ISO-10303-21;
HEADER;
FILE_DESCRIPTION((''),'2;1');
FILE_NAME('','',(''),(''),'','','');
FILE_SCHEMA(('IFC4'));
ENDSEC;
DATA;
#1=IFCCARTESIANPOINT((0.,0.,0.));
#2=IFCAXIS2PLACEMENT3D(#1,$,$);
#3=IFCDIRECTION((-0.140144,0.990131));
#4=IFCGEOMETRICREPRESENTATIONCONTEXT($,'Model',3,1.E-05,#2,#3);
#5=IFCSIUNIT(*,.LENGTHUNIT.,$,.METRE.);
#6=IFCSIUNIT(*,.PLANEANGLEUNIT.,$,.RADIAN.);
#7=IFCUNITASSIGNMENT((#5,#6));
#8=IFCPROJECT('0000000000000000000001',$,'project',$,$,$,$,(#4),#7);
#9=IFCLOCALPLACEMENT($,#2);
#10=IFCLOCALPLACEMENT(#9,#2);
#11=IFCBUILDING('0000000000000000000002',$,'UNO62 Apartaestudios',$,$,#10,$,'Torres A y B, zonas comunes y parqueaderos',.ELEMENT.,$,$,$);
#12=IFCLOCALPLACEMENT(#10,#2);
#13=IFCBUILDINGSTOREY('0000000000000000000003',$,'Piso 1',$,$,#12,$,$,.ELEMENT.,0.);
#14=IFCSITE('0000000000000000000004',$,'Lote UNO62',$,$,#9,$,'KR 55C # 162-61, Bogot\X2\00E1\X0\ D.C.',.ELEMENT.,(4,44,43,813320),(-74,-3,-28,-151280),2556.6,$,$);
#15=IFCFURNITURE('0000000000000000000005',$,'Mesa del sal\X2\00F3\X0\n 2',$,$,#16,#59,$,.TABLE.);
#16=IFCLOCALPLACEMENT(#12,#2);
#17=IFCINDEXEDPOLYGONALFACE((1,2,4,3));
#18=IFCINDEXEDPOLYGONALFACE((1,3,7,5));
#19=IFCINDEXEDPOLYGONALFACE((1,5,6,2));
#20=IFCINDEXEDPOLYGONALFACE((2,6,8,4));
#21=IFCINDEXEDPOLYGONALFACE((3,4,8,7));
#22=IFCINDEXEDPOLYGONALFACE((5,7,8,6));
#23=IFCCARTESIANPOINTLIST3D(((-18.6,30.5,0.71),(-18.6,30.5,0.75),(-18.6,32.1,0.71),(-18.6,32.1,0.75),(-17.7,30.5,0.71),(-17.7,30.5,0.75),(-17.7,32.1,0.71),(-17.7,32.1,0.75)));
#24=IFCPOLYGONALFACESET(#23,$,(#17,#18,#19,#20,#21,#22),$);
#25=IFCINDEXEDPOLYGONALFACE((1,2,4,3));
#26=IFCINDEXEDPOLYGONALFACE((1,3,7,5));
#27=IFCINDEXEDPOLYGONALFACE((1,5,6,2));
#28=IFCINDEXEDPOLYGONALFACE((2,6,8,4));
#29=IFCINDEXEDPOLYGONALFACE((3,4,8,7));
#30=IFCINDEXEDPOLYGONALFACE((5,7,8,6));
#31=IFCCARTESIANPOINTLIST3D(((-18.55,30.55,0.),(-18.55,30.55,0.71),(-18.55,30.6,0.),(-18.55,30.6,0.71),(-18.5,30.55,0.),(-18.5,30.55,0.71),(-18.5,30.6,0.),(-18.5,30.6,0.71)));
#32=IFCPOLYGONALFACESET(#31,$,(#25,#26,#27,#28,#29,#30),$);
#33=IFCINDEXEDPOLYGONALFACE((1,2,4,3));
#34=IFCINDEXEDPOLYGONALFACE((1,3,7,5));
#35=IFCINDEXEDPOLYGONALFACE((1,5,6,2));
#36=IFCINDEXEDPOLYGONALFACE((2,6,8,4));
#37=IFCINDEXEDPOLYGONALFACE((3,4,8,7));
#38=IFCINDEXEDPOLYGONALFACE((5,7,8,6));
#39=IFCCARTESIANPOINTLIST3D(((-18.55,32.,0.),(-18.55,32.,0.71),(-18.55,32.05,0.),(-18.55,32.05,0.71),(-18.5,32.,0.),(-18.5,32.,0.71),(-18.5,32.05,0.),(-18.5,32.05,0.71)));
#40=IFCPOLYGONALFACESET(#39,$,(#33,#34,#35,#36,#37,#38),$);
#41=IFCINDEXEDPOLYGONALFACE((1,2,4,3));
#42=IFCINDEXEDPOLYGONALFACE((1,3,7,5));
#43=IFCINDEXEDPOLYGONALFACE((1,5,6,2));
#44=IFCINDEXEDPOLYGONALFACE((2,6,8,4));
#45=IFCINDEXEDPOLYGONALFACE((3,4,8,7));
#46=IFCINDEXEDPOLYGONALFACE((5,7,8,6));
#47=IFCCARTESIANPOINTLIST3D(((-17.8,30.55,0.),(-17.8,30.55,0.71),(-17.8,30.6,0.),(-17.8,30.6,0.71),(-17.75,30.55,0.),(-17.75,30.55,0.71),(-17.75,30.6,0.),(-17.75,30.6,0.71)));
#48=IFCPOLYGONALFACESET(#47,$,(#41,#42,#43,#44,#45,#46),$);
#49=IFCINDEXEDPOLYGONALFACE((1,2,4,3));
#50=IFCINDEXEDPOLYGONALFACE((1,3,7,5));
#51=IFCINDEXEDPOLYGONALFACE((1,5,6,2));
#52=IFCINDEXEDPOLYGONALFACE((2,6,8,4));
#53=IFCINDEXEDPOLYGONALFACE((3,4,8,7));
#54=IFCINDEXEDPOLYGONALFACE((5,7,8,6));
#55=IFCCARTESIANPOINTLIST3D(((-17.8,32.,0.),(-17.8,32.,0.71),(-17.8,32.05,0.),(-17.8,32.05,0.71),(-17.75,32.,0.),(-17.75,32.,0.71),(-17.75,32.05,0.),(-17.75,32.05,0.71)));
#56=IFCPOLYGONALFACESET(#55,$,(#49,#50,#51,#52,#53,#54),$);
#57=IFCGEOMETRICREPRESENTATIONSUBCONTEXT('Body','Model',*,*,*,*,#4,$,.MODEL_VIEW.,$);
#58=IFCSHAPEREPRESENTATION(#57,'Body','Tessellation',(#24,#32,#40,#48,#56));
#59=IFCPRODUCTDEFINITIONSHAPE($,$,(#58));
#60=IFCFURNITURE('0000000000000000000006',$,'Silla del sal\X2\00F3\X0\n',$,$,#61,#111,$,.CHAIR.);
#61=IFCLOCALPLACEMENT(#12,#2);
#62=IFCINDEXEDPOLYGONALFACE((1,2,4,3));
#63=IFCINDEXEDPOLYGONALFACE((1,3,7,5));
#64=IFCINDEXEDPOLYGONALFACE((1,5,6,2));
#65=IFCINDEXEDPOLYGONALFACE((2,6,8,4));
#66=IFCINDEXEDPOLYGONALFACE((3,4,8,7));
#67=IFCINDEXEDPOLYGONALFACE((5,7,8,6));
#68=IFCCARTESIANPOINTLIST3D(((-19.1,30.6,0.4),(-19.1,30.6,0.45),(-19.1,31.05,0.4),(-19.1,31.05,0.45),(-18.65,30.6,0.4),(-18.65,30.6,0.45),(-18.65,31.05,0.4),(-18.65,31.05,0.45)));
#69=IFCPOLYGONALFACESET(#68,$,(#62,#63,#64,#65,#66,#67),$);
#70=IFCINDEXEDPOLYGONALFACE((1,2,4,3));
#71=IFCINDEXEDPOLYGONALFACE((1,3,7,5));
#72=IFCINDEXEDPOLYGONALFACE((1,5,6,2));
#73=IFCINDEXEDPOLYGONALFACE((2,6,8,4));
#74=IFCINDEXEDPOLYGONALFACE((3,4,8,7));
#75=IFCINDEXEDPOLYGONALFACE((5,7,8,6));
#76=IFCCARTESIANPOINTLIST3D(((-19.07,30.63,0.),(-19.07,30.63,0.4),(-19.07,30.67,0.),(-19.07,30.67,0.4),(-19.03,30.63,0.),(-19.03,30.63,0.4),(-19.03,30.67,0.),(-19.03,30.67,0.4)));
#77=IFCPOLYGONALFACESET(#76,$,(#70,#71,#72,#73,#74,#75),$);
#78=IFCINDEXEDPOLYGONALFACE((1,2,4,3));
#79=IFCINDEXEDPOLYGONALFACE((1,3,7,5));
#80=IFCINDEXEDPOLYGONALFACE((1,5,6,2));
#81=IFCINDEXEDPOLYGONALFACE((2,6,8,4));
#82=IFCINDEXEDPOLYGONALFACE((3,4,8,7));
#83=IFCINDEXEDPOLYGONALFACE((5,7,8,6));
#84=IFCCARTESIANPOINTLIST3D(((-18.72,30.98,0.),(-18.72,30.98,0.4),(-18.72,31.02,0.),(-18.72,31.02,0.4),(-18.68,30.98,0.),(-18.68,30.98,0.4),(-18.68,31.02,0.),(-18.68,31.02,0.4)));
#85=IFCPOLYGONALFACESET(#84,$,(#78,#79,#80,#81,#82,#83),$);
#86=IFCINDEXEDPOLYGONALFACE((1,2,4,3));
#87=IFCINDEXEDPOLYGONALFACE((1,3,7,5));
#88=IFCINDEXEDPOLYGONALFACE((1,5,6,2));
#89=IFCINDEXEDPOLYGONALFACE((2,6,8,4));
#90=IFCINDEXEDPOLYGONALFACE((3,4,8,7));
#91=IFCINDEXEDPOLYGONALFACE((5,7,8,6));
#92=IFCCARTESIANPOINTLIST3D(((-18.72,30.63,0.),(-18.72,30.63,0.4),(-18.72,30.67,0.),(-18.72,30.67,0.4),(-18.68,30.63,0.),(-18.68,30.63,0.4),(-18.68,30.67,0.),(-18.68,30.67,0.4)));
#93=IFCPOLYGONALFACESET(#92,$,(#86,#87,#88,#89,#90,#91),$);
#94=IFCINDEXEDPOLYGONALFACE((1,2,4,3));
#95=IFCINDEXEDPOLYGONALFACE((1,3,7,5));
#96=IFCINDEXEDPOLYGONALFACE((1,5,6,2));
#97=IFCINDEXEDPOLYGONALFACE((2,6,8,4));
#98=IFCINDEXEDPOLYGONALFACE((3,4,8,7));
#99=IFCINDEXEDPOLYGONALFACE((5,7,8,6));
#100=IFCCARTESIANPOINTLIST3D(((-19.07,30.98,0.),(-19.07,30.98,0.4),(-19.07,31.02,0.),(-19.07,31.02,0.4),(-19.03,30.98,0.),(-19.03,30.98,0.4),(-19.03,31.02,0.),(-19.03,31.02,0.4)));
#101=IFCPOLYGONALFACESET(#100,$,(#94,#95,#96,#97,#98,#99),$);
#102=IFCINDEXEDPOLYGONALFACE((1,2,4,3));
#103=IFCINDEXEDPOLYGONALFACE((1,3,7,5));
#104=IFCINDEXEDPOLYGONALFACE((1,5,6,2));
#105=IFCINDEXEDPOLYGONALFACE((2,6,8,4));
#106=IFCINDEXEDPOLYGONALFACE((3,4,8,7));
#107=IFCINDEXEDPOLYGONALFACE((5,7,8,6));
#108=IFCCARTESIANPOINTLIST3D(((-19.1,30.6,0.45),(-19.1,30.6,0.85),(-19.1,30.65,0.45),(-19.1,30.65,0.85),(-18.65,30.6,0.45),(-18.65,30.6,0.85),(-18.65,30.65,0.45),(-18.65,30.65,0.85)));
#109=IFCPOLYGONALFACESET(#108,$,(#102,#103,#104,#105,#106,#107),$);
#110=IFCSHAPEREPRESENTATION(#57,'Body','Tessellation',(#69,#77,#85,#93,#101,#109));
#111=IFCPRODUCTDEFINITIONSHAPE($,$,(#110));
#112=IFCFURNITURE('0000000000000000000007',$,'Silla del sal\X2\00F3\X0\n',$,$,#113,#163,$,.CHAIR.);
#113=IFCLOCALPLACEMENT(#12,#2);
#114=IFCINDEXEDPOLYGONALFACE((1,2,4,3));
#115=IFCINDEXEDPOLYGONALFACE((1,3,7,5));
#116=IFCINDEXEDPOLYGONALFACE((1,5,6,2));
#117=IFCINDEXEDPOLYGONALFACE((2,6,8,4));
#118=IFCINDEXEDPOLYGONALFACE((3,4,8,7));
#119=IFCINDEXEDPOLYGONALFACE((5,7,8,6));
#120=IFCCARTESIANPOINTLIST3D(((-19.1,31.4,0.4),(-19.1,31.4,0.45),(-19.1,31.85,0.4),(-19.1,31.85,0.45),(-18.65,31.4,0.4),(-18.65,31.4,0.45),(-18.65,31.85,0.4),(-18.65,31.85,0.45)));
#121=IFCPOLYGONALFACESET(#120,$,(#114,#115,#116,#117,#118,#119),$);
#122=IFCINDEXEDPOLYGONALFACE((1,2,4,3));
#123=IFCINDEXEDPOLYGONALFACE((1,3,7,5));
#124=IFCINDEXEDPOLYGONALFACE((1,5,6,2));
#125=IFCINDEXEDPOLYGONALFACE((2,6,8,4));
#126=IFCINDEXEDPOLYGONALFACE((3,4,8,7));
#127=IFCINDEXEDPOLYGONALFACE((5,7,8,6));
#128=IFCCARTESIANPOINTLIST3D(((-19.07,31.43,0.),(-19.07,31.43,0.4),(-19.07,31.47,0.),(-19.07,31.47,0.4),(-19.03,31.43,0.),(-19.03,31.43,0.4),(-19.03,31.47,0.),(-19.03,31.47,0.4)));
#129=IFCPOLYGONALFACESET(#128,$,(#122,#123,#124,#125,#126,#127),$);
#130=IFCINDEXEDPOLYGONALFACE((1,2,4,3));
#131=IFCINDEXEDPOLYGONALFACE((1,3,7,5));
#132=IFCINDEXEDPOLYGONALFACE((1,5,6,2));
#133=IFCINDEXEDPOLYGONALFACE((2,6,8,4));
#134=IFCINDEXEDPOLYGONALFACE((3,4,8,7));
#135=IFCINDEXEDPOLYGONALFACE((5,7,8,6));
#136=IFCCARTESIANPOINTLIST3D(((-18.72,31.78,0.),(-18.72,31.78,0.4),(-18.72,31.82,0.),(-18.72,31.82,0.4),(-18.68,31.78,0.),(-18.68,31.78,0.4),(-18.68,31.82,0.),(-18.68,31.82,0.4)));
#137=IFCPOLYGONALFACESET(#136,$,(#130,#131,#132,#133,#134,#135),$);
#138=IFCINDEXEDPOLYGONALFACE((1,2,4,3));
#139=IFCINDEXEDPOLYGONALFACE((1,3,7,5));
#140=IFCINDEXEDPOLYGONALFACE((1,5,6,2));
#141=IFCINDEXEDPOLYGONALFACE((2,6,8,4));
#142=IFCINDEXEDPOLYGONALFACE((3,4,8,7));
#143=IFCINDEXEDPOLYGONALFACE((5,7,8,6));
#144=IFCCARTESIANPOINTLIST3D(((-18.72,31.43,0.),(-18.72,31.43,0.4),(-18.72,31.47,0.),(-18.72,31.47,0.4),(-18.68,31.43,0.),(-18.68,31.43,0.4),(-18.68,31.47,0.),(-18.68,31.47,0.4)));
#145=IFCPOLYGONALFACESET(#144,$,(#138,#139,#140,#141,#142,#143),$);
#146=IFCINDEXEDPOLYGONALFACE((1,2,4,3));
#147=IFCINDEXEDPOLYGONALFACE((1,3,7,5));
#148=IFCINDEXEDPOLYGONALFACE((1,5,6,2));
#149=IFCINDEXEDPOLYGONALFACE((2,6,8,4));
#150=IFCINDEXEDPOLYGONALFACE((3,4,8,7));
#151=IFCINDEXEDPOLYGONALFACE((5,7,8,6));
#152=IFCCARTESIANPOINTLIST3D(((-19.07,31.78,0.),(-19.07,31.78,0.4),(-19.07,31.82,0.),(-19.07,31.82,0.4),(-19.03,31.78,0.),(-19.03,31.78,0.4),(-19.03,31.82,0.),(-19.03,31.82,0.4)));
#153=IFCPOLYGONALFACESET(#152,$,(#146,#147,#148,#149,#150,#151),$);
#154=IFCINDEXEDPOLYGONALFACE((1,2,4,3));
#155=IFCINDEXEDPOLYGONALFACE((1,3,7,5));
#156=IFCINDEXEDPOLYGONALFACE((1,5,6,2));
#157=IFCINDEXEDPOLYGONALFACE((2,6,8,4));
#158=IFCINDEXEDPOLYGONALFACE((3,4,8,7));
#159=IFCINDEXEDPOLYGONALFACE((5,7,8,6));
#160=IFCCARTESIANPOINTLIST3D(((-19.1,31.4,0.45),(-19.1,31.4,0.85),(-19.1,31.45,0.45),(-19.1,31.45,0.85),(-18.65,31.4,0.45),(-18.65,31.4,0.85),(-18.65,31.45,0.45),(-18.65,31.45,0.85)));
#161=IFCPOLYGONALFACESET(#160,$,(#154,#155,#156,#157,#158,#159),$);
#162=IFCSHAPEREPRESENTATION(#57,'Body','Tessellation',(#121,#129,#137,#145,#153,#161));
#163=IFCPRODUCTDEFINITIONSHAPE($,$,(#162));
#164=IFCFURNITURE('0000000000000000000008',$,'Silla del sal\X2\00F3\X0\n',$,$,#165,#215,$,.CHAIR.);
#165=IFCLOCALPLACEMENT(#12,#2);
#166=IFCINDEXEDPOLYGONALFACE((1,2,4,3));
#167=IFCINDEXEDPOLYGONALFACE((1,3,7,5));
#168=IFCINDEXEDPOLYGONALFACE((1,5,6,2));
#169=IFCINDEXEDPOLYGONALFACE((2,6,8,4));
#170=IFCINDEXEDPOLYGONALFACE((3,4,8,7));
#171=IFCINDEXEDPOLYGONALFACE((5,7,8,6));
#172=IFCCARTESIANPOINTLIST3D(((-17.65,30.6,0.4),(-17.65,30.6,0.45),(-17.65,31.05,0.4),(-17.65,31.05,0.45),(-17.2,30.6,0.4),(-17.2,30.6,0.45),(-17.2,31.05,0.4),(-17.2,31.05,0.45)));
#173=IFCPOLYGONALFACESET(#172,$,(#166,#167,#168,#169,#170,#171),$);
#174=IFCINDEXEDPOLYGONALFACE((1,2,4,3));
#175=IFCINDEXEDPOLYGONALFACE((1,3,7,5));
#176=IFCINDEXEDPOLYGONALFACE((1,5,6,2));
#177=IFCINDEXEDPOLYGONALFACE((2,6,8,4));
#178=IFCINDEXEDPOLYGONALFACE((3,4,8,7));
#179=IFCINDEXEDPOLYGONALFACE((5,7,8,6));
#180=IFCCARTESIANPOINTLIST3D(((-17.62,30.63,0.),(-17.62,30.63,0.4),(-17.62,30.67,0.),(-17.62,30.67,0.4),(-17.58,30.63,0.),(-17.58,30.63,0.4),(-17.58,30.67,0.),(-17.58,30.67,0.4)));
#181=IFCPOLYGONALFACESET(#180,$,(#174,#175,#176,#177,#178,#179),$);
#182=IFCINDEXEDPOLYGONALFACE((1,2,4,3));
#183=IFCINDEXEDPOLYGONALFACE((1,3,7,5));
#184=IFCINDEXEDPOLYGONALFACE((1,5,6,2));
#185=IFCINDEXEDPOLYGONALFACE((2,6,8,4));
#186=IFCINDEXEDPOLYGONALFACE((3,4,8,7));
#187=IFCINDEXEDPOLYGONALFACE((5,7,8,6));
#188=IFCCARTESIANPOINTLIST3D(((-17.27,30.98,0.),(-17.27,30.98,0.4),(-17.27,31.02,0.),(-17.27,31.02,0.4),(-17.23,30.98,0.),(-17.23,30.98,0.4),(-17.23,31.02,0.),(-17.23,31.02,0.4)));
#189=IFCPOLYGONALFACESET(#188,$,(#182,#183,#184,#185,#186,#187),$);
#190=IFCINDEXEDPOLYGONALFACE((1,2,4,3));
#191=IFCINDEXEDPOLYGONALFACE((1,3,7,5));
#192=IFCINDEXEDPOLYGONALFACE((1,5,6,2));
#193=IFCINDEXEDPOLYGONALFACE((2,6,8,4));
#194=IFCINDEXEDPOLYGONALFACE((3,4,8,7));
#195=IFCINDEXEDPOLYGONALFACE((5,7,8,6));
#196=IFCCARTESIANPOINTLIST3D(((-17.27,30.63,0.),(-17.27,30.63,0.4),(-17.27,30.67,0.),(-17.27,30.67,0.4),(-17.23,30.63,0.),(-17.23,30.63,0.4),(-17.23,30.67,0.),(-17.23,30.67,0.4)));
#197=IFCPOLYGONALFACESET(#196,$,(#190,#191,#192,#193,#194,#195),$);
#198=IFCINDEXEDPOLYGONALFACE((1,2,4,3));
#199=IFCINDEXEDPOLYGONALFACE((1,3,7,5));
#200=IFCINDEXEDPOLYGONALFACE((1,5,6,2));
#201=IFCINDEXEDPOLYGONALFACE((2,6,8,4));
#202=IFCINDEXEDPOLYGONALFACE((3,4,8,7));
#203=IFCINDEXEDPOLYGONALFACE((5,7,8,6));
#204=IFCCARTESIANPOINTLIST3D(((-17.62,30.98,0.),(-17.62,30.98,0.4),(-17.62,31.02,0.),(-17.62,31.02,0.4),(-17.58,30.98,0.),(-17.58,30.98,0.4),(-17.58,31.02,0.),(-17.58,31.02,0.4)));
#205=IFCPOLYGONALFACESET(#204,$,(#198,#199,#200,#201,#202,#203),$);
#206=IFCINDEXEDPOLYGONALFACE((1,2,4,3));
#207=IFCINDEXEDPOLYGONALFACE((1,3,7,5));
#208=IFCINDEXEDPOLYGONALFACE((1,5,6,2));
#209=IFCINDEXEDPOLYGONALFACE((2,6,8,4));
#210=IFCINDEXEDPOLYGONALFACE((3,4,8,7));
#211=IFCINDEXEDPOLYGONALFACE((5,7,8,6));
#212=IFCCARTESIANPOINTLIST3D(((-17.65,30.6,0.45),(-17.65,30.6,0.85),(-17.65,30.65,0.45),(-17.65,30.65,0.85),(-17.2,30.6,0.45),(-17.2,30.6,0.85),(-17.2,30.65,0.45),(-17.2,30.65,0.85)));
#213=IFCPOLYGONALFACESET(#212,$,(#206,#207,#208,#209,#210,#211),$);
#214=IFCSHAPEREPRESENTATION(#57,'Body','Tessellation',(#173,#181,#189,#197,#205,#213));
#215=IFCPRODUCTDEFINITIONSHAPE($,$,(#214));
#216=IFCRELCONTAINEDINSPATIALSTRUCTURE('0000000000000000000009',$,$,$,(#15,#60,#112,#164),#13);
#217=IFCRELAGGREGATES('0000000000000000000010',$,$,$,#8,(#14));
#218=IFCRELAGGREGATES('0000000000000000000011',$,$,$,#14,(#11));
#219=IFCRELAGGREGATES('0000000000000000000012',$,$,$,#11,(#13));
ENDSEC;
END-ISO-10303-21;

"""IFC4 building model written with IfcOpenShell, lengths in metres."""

from ifc_helpers import new_model, si_unit, direction, frame, frame_2d, origin, place, context, subcontext, project, spatial, rectangle, extrude, element, save


model = new_model("IFC4")

# Units and contexts
model_context = context("Model", 3, precision=1e-05, world=origin(), true_north=direction((-0.140144, 0.990131)))
body_context = subcontext(model_context, "Body", "Model", "MODEL_VIEW")
ifc_project = project(units=[si_unit("LENGTHUNIT", "METRE"), si_unit("PLANEANGLEUNIT", "RADIAN")], contexts=[model_context])

# Site, building, storey
site_placement = place(None, origin())
site = spatial("IfcSite", under=ifc_project, at=site_placement, Name="Lote UNO62", LongName="KR 55C # 162-61, Bogotá D.C.", CompositionType="ELEMENT", RefLatitude=(4, 44, 43, 813320), RefLongitude=(-74, -3, -28, -151280), RefElevation=2556.6)
building_placement = place(site_placement, origin())
building = spatial("IfcBuilding", under=site, at=building_placement, Name="UNO62 Apartaestudios", LongName="Torres A y B, zonas comunes y parqueaderos", CompositionType="ELEMENT")
storey_placement = place(building_placement, origin())
storey = spatial("IfcBuildingStorey", under=building, at=storey_placement, Name="Piso 1", CompositionType="ELEMENT", Elevation=0.0)

# Furniture
furniture_1_placement = place(storey_placement, origin())
element("IfcFurniture", 1, at=furniture_1_placement, inside=storey, Name="Mesa del salón 2", PredefinedType="TABLE", context=body_context, shape_type="SweptSolid", body=[
    extrude(rectangle(XDim=0.9, YDim=1.6, at=frame_2d((-18.15, 31.3))), frame((0.0, 0.0, 0.71)), (0.0, 0.0, 1.0), 0.04),
    extrude(rectangle(XDim=0.05, YDim=0.05, at=frame_2d((-18.525, 30.575))), origin(), (0.0, 0.0, 1.0), 0.71),
    extrude(rectangle(XDim=0.05, YDim=0.05, at=frame_2d((-18.525, 32.025))), origin(), (0.0, 0.0, 1.0), 0.71),
    extrude(rectangle(XDim=0.05, YDim=0.05, at=frame_2d((-17.775, 30.575))), origin(), (0.0, 0.0, 1.0), 0.71),
    extrude(rectangle(XDim=0.05, YDim=0.05, at=frame_2d((-17.775, 32.025))), origin(), (0.0, 0.0, 1.0), 0.71),
])
furniture_2_placement = place(storey_placement, origin())
element("IfcFurniture", 2, at=furniture_2_placement, inside=storey, Name="Silla del salón", PredefinedType="CHAIR", context=body_context, shape_type="SweptSolid", body=[
    extrude(rectangle(XDim=0.45, YDim=0.45, at=frame_2d((-18.875, 30.825))), frame((0.0, 0.0, 0.4)), (0.0, 0.0, 1.0), 0.05),
    extrude(rectangle(XDim=0.04, YDim=0.04, at=frame_2d((-19.05, 30.65))), origin(), (0.0, 0.0, 1.0), 0.4),
    extrude(rectangle(XDim=0.04, YDim=0.04, at=frame_2d((-18.7, 31.0))), origin(), (0.0, 0.0, 1.0), 0.4),
    extrude(rectangle(XDim=0.04, YDim=0.04, at=frame_2d((-18.7, 30.65))), origin(), (0.0, 0.0, 1.0), 0.4),
    extrude(rectangle(XDim=0.04, YDim=0.04, at=frame_2d((-19.05, 31.0))), origin(), (0.0, 0.0, 1.0), 0.4),
    extrude(rectangle(XDim=0.45, YDim=0.05, at=frame_2d((-18.875, 30.625))), frame((0.0, 0.0, 0.45)), (0.0, 0.0, 1.0), 0.4),
])
furniture_3_placement = place(storey_placement, origin())
element("IfcFurniture", 3, at=furniture_3_placement, inside=storey, Name="Silla del salón", PredefinedType="CHAIR", context=body_context, shape_type="SweptSolid", body=[
    extrude(rectangle(XDim=0.45, YDim=0.45, at=frame_2d((-18.875, 31.625))), frame((0.0, 0.0, 0.4)), (0.0, 0.0, 1.0), 0.05),
    extrude(rectangle(XDim=0.04, YDim=0.04, at=frame_2d((-19.05, 31.45))), origin(), (0.0, 0.0, 1.0), 0.4),
    extrude(rectangle(XDim=0.04, YDim=0.04, at=frame_2d((-18.7, 31.8))), origin(), (0.0, 0.0, 1.0), 0.4),
    extrude(rectangle(XDim=0.04, YDim=0.04, at=frame_2d((-18.7, 31.45))), origin(), (0.0, 0.0, 1.0), 0.4),
    extrude(rectangle(XDim=0.04, YDim=0.04, at=frame_2d((-19.05, 31.8))), origin(), (0.0, 0.0, 1.0), 0.4),
    extrude(rectangle(XDim=0.45, YDim=0.05, at=frame_2d((-18.875, 31.425))), frame((0.0, 0.0, 0.45)), (0.0, 0.0, 1.0), 0.4),
])
furniture_4_placement = place(storey_placement, origin())
element("IfcFurniture", 4, at=furniture_4_placement, inside=storey, Name="Silla del salón", PredefinedType="CHAIR", context=body_context, shape_type="SweptSolid", body=[
    extrude(rectangle(XDim=0.45, YDim=0.45, at=frame_2d((-17.425, 30.825))), frame((0.0, 0.0, 0.4)), (0.0, 0.0, 1.0), 0.05),
    extrude(rectangle(XDim=0.04, YDim=0.04, at=frame_2d((-17.6, 30.65))), origin(), (0.0, 0.0, 1.0), 0.4),
    extrude(rectangle(XDim=0.04, YDim=0.04, at=frame_2d((-17.25, 31.0))), origin(), (0.0, 0.0, 1.0), 0.4),
    extrude(rectangle(XDim=0.04, YDim=0.04, at=frame_2d((-17.25, 30.65))), origin(), (0.0, 0.0, 1.0), 0.4),
    extrude(rectangle(XDim=0.04, YDim=0.04, at=frame_2d((-17.6, 31.0))), origin(), (0.0, 0.0, 1.0), 0.4),
    extrude(rectangle(XDim=0.45, YDim=0.05, at=frame_2d((-17.425, 30.625))), frame((0.0, 0.0, 0.45)), (0.0, 0.0, 1.0), 0.4),
])

save(model, "model.ifc")
